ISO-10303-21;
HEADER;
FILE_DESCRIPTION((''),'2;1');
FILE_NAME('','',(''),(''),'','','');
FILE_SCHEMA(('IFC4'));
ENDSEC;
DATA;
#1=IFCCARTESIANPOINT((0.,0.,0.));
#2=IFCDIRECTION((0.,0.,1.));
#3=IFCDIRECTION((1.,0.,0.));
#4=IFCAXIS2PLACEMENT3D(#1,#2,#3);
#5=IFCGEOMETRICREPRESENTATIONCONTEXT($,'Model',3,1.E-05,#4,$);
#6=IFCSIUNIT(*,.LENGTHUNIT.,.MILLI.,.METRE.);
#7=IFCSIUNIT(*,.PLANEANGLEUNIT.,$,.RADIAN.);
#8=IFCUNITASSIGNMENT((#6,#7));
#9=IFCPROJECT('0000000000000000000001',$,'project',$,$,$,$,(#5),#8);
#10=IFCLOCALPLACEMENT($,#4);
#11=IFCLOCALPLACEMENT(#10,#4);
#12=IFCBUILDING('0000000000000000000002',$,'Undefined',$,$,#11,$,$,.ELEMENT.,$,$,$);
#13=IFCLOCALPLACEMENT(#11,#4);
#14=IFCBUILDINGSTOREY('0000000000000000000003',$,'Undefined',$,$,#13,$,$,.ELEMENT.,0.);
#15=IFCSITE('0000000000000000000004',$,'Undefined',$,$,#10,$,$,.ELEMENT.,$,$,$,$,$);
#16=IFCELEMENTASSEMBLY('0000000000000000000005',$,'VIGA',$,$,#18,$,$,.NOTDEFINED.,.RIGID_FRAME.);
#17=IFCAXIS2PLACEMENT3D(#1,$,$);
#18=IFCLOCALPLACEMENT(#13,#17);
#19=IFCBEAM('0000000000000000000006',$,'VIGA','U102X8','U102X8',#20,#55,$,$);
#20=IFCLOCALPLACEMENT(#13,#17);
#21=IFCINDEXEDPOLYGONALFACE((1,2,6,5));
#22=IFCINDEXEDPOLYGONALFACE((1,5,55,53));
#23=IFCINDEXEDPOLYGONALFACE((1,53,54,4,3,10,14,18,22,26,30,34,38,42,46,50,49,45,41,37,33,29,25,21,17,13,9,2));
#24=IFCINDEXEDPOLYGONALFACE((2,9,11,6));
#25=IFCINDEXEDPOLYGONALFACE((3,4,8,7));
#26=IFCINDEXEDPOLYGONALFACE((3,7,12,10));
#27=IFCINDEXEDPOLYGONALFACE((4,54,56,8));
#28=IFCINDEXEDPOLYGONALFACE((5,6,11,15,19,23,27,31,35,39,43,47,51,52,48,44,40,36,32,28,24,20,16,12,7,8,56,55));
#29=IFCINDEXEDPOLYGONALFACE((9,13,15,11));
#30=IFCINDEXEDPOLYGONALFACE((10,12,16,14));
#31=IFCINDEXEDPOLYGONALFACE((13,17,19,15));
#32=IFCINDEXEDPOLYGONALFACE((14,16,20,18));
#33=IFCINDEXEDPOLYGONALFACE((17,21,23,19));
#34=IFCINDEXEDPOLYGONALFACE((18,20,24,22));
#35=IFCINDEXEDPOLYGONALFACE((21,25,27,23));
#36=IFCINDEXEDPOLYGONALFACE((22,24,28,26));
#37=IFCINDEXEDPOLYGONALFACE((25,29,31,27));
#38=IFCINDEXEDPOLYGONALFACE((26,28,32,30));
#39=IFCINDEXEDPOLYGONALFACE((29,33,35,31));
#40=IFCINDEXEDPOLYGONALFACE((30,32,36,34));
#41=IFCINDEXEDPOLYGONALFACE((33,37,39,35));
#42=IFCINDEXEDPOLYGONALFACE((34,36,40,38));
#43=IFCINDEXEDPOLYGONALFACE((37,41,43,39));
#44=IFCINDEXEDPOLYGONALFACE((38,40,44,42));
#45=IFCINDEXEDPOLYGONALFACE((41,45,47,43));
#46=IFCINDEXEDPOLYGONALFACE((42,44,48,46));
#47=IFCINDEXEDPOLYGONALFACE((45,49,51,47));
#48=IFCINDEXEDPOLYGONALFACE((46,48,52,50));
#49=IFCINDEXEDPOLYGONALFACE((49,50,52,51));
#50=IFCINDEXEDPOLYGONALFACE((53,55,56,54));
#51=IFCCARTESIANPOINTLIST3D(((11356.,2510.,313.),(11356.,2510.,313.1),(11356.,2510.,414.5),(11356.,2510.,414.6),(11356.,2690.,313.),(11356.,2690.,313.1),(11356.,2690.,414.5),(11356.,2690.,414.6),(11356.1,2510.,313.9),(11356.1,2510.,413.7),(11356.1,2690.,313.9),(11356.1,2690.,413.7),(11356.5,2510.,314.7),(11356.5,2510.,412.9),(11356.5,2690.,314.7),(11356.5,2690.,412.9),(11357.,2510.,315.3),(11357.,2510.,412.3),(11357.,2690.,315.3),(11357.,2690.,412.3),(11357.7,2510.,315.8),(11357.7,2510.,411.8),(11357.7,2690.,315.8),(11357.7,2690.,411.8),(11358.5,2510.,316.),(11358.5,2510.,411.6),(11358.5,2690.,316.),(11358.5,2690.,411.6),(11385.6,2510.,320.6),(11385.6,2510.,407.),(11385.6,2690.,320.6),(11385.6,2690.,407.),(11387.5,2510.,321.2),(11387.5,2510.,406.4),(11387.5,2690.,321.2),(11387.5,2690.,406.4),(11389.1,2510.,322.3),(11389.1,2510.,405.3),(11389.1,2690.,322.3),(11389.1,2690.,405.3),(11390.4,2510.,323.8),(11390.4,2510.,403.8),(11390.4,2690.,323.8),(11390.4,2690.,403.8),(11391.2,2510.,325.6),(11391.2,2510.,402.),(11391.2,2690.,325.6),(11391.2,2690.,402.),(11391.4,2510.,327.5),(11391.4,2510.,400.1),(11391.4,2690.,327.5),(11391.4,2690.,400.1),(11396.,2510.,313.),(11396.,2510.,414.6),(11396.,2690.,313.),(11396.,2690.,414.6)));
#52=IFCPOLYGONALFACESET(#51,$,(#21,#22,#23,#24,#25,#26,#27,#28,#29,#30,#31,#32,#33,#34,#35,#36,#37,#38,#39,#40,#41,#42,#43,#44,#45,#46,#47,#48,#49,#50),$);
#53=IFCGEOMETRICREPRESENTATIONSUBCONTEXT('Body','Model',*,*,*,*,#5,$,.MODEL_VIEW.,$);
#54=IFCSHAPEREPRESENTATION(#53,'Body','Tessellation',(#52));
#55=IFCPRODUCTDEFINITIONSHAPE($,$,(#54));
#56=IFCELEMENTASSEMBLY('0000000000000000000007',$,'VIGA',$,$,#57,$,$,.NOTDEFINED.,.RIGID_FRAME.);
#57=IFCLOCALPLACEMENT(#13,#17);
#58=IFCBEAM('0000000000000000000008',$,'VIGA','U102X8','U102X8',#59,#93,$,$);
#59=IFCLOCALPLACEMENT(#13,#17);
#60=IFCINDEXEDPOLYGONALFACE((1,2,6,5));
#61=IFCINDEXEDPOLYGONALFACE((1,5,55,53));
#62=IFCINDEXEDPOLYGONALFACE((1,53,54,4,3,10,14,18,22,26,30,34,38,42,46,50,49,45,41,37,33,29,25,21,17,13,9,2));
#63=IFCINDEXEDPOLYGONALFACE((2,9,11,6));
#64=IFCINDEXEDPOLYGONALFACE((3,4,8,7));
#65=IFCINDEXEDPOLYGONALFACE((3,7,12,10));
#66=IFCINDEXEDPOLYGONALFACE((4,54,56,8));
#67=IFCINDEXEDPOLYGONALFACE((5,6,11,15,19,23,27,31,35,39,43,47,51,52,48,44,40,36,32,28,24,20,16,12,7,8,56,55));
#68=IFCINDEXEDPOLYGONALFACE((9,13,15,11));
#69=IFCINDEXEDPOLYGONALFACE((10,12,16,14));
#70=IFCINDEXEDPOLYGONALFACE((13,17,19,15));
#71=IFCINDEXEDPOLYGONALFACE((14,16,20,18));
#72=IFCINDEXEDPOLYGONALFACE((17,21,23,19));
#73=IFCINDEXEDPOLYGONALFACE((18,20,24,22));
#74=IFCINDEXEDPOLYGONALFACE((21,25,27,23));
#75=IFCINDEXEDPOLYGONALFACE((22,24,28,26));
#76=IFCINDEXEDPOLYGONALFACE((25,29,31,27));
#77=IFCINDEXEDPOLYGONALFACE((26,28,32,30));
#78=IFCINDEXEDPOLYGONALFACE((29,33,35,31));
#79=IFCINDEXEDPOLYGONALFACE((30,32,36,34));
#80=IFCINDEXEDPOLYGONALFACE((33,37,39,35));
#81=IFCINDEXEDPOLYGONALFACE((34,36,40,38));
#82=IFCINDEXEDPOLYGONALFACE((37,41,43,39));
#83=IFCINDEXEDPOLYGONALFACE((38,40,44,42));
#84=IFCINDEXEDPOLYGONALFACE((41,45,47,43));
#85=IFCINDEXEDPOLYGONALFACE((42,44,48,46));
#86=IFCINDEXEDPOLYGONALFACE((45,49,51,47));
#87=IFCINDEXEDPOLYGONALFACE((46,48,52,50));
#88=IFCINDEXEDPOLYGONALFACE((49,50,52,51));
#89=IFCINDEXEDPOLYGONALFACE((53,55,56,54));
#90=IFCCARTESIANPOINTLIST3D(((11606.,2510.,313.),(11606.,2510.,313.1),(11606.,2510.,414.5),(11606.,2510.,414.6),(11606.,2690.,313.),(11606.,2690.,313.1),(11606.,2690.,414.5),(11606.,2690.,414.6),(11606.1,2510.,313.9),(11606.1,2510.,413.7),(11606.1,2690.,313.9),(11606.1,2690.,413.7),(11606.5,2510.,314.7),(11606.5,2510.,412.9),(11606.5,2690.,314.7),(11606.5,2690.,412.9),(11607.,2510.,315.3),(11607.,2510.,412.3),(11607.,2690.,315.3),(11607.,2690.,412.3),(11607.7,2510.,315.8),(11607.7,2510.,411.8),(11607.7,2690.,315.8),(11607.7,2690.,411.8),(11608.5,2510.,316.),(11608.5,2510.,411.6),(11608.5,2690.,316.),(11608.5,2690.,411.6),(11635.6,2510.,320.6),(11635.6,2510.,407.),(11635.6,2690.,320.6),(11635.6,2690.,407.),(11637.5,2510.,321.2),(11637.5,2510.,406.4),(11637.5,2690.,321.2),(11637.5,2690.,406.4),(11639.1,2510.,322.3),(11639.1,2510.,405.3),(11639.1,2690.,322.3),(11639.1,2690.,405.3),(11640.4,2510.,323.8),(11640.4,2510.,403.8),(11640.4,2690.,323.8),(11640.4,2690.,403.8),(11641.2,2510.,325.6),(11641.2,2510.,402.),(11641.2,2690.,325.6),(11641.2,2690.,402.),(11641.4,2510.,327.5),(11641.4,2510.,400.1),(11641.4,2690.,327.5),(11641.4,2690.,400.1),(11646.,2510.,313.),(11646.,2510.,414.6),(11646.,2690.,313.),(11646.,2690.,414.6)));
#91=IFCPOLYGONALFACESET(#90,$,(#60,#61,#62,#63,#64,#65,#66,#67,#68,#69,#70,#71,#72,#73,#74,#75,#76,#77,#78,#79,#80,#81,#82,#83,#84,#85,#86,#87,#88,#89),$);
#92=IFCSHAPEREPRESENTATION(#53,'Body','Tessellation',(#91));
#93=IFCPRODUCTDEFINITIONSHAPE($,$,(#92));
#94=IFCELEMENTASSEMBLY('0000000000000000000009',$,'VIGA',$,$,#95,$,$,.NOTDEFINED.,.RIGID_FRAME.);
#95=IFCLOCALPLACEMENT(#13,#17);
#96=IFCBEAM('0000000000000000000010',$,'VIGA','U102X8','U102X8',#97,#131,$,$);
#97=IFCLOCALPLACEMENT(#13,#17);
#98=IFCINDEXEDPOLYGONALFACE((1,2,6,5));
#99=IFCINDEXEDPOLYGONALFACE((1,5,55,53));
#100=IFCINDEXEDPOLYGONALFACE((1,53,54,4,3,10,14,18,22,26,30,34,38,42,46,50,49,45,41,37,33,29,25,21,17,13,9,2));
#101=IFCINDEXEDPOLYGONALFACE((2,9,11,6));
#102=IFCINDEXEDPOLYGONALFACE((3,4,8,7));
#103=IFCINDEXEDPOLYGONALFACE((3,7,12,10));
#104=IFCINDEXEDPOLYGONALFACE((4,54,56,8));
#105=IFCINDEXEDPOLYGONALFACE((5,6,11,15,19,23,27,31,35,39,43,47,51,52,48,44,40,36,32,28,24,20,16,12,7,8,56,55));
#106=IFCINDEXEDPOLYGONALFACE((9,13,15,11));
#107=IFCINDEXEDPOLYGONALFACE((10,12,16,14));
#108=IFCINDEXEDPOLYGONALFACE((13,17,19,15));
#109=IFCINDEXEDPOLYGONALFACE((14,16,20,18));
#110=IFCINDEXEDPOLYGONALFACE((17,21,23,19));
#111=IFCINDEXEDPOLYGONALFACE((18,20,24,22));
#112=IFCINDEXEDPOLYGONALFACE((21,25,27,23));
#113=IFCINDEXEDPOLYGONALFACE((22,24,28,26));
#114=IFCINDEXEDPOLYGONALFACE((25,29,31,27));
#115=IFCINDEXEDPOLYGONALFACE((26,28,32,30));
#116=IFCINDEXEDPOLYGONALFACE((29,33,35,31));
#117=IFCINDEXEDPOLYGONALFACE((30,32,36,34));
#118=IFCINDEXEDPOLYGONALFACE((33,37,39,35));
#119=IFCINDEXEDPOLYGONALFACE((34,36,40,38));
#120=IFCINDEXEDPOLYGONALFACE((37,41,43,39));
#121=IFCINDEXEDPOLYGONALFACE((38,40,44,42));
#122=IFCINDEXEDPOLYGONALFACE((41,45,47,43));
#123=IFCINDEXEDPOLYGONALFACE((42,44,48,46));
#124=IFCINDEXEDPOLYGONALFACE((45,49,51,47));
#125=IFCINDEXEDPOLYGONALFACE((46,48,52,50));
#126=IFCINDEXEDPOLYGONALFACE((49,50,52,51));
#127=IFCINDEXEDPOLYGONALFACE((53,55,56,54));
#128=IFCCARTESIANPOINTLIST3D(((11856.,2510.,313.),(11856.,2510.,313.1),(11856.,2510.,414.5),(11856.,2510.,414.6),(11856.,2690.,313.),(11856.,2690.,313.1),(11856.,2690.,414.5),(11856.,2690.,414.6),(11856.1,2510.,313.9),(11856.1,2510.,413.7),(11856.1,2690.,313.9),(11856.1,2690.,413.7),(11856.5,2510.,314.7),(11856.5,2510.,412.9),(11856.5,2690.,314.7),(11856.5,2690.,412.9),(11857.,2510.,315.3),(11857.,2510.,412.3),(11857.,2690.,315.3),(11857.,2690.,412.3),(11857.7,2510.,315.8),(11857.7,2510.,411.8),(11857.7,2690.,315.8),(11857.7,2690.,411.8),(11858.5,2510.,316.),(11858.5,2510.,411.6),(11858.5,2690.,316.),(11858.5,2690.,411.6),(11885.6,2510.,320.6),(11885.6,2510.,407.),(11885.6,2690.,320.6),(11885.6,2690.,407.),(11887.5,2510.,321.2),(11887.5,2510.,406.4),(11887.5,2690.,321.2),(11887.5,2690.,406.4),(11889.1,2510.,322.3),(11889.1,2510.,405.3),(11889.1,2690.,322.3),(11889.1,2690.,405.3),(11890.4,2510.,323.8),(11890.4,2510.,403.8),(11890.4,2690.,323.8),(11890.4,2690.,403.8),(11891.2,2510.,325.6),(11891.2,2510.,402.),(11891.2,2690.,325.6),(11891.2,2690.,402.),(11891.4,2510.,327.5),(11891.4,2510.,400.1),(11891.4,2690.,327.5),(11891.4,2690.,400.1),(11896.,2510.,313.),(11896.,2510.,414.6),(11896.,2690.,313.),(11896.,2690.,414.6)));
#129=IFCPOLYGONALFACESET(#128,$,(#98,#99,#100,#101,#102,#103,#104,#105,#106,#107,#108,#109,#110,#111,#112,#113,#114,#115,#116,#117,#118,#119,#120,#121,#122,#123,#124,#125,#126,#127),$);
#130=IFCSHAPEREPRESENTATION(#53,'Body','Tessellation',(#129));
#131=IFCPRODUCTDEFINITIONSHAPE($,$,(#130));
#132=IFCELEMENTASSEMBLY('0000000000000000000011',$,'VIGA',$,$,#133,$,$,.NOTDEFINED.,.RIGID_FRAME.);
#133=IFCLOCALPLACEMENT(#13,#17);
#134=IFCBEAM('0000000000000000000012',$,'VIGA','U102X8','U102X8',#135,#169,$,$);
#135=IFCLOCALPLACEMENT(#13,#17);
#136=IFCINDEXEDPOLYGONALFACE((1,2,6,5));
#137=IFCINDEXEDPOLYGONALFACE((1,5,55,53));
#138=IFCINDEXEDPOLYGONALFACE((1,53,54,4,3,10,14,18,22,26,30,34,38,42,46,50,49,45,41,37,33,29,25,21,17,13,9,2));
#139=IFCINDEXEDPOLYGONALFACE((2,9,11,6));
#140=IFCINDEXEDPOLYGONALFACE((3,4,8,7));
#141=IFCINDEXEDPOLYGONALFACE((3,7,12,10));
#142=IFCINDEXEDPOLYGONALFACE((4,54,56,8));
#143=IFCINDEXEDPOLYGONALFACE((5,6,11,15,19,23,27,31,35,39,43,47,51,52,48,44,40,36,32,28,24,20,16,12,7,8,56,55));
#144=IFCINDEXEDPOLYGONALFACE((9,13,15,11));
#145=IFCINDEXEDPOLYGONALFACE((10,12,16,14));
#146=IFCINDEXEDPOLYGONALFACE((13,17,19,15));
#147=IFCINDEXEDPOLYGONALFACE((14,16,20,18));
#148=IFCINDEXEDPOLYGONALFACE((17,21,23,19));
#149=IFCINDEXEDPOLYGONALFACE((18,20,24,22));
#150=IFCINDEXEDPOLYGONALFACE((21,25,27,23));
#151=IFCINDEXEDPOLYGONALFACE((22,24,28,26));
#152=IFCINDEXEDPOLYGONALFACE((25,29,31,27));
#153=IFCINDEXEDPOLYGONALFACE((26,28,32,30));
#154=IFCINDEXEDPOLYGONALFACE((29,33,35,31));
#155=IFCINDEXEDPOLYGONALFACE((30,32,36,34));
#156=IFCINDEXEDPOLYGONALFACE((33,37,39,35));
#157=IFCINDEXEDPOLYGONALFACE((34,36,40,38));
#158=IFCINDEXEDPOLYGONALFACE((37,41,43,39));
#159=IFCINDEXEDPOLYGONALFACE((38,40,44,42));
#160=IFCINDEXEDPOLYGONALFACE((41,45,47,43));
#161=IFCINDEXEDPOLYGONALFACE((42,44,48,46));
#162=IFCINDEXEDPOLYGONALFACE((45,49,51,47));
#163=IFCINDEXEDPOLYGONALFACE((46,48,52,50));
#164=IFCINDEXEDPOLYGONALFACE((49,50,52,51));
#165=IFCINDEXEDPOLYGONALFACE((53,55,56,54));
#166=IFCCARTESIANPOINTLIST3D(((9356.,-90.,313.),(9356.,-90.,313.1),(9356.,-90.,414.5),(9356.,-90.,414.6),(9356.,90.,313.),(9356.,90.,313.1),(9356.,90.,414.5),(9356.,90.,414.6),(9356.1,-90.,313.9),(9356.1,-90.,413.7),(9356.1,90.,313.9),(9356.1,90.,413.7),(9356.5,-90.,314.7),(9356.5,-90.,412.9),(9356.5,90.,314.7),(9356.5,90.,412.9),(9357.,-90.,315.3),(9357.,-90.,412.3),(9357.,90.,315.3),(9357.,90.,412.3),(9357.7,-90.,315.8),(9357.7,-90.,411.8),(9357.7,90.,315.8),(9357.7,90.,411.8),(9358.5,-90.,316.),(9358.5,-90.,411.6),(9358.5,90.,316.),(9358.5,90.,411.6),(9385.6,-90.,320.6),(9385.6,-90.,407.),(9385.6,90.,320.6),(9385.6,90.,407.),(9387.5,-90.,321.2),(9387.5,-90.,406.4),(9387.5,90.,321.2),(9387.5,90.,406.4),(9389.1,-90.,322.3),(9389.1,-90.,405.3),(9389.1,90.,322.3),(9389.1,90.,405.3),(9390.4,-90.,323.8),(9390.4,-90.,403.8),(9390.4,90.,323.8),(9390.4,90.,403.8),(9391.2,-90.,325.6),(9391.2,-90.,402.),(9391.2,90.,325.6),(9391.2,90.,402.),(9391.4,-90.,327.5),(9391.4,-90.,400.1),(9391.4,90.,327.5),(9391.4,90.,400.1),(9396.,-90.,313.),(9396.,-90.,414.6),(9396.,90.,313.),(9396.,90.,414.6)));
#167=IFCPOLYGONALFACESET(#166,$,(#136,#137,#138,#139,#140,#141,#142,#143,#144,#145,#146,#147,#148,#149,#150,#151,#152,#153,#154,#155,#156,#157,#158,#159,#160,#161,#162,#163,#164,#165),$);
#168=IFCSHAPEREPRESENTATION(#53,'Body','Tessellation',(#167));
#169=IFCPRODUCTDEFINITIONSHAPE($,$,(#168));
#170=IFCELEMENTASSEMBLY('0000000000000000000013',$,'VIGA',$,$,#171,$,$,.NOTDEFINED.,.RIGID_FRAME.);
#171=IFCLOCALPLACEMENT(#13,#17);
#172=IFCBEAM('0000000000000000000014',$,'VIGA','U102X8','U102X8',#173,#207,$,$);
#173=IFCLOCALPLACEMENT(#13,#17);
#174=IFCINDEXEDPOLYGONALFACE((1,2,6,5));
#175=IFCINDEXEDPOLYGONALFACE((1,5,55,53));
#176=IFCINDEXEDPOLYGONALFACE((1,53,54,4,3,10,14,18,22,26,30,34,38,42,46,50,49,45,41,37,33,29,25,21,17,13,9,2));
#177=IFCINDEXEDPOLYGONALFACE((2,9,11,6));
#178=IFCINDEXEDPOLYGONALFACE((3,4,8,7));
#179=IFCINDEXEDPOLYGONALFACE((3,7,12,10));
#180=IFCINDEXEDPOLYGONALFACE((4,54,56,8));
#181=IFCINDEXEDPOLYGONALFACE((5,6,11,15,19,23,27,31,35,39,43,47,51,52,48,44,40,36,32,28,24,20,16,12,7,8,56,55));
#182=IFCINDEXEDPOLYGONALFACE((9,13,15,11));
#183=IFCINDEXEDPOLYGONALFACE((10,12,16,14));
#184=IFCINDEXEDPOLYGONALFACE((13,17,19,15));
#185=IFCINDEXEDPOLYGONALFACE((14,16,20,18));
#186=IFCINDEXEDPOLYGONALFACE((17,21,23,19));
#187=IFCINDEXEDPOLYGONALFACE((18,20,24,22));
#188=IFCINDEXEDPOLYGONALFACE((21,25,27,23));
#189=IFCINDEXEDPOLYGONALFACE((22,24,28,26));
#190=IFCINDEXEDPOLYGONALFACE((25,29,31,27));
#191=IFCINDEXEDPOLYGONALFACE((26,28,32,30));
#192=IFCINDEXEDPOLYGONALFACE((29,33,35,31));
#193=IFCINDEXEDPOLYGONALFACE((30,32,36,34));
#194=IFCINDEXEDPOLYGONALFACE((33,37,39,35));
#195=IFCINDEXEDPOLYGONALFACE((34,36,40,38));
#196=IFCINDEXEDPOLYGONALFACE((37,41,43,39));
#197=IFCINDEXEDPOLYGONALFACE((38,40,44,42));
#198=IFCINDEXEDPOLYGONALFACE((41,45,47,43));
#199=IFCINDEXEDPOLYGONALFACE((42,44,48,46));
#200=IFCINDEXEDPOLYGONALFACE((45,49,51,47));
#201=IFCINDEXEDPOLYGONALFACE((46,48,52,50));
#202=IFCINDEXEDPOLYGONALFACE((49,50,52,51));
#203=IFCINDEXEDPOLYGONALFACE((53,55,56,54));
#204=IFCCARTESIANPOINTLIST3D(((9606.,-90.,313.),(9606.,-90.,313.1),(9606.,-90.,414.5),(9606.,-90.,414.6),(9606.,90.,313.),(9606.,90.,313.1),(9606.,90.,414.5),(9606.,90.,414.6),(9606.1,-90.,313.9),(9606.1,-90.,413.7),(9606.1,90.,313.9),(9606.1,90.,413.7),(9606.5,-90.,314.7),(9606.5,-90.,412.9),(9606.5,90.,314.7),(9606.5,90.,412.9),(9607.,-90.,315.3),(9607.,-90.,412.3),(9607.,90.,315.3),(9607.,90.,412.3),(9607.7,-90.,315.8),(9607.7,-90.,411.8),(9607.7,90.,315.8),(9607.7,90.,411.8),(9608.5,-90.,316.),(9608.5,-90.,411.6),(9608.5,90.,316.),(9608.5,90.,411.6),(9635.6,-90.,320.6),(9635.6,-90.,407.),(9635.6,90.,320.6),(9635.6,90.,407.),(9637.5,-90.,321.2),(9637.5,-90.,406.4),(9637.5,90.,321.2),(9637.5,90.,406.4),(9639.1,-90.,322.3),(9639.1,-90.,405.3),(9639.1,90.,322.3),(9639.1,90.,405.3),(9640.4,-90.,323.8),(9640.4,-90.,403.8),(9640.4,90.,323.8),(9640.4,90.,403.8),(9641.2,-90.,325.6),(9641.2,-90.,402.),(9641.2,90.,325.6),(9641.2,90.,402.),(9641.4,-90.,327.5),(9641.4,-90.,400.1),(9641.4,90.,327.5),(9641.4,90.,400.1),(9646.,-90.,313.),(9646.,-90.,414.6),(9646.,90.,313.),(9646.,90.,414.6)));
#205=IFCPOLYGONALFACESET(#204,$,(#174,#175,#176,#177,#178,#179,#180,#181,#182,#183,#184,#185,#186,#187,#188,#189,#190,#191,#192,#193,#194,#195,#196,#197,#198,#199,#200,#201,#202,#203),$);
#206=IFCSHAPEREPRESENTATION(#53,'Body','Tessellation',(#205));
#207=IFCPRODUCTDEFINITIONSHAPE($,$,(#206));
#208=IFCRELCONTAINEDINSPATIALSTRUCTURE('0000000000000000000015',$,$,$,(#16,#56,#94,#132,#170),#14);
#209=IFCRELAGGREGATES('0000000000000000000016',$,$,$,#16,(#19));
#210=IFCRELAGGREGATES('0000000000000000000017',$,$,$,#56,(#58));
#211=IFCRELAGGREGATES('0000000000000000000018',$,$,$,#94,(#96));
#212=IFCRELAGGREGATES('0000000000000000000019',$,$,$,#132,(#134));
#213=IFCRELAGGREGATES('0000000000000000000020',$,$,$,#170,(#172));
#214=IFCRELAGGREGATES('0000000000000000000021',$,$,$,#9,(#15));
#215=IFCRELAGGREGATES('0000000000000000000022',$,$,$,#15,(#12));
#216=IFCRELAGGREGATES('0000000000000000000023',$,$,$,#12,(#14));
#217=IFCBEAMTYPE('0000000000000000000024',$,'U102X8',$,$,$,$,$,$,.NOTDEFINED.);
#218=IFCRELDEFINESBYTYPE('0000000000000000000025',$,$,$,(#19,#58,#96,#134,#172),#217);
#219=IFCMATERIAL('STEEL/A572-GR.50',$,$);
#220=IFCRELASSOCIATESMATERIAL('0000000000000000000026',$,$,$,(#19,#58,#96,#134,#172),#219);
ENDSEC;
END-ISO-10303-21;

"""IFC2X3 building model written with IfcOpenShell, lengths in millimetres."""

from ifc_helpers import new_model, si_unit, frame, origin_with_axes, origin_2d_with_axis, place, context, subcontext, project, spatial, u_section, extrude, material, type_object, element, aggregate, save


model = new_model("IFC2X3")

# Units and contexts
model_context = context("Model", 3, precision=1e-05, world=origin_with_axes())
body_context = subcontext(model_context, "Body", "Model", "MODEL_VIEW")
ifc_project = project(units=[si_unit("LENGTHUNIT", "METRE", prefix="MILLI"), si_unit("PLANEANGLEUNIT", "RADIAN")], contexts=[model_context])

# Site, building, storey
site_placement = place(None, origin_with_axes())
site = spatial("IfcSite", under=ifc_project, at=site_placement, Name="Undefined", CompositionType="ELEMENT")
building_placement = place(site_placement, origin_with_axes())
building = spatial("IfcBuilding", under=site, at=building_placement, Name="Undefined", CompositionType="ELEMENT")
storey_placement = place(building_placement, origin_with_axes())
storey = spatial("IfcBuildingStorey", under=building, at=storey_placement, Name="Undefined", CompositionType="ELEMENT", Elevation=0.0)

# Element assemblies, beams
ifc_material_1 = material(Name="STEEL/A572-GR.50")
beam_type_1 = type_object("IfcBeamType", Name="U102X8", PredefinedType="NOTDEFINED")
assembly_1_placement = place(storey_placement, origin_with_axes())
assembly_1 = element("IfcElementAssembly", 1, at=assembly_1_placement, inside=storey, Name="VIGA", AssemblyPlace="NOTDEFINED", PredefinedType="RIGID_FRAME")
beam_1_placement = place(assembly_1_placement, frame((11376.0, 2690.0, 363.8), z_axis=(0.0, 0.0, 1.0), x_axis=(0.0, -1.0, 0.0)))
beam_1 = element("IfcBeam", 2, at=beam_1_placement, type_object=beam_type_1, material=ifc_material_1, Name="VIGA", Description="U102X8", ObjectType="U102X8", context=body_context, shape_type="SweptSolid", body=[
    extrude(u_section(Depth=101.6, FlangeWidth=40.0, WebThickness=4.6, FlangeThickness=6.0, FilletRadius=7.0, EdgeRadius=3.0, FlangeSlope=0.16839, at=origin_2d_with_axis()), frame((180.0, 0.0, 0.0), z_axis=(-1.0, 0.0, 0.0), x_axis=(0.0, -1.0, 0.0)), (0.0, 0.0, 1.0), 180.0),
])
aggregate(assembly_1, [beam_1])
assembly_2_placement = place(storey_placement, origin_with_axes())
assembly_2 = element("IfcElementAssembly", 3, at=assembly_2_placement, inside=storey, Name="VIGA", AssemblyPlace="NOTDEFINED", PredefinedType="RIGID_FRAME")
beam_2_placement = place(assembly_2_placement, frame((11626.0, 2690.0, 363.8), z_axis=(0.0, 0.0, 1.0), x_axis=(0.0, -1.0, 0.0)))
beam_2 = element("IfcBeam", 4, at=beam_2_placement, type_object=beam_type_1, material=ifc_material_1, Name="VIGA", Description="U102X8", ObjectType="U102X8", context=body_context, shape_type="SweptSolid", body=[
    extrude(u_section(Depth=101.6, FlangeWidth=40.0, WebThickness=4.6, FlangeThickness=6.0, FilletRadius=7.0, EdgeRadius=3.0, FlangeSlope=0.16839, at=origin_2d_with_axis()), frame((180.0, 0.0, 0.0), z_axis=(-1.0, 0.0, 0.0), x_axis=(0.0, -1.0, 0.0)), (0.0, 0.0, 1.0), 180.0),
])
aggregate(assembly_2, [beam_2])
assembly_3_placement = place(storey_placement, origin_with_axes())
assembly_3 = element("IfcElementAssembly", 5, at=assembly_3_placement, inside=storey, Name="VIGA", AssemblyPlace="NOTDEFINED", PredefinedType="RIGID_FRAME")
beam_3_placement = place(assembly_3_placement, frame((11876.0, 2690.0, 363.8), z_axis=(0.0, 0.0, 1.0), x_axis=(0.0, -1.0, 0.0)))
beam_3 = element("IfcBeam", 6, at=beam_3_placement, type_object=beam_type_1, material=ifc_material_1, Name="VIGA", Description="U102X8", ObjectType="U102X8", context=body_context, shape_type="SweptSolid", body=[
    extrude(u_section(Depth=101.6, FlangeWidth=40.0, WebThickness=4.6, FlangeThickness=6.0, FilletRadius=7.0, EdgeRadius=3.0, FlangeSlope=0.16839, at=origin_2d_with_axis()), frame((180.0, 0.0, 0.0), z_axis=(-1.0, 0.0, 0.0), x_axis=(0.0, -1.0, 0.0)), (0.0, 0.0, 1.0), 180.0),
])
aggregate(assembly_3, [beam_3])
assembly_4_placement = place(storey_placement, origin_with_axes())
assembly_4 = element("IfcElementAssembly", 7, at=assembly_4_placement, inside=storey, Name="VIGA", AssemblyPlace="NOTDEFINED", PredefinedType="RIGID_FRAME")
beam_4_placement = place(assembly_4_placement, frame((9376.0, 90.0, 363.8), z_axis=(0.0, 0.0, 1.0), x_axis=(0.0, -1.0, 0.0)))
beam_4 = element("IfcBeam", 8, at=beam_4_placement, type_object=beam_type_1, material=ifc_material_1, Name="VIGA", Description="U102X8", ObjectType="U102X8", context=body_context, shape_type="SweptSolid", body=[
    extrude(u_section(Depth=101.6, FlangeWidth=40.0, WebThickness=4.6, FlangeThickness=6.0, FilletRadius=7.0, EdgeRadius=3.0, FlangeSlope=0.16839, at=origin_2d_with_axis()), frame((180.0, 0.0, 0.0), z_axis=(-1.0, 0.0, 0.0), x_axis=(0.0, -1.0, 0.0)), (0.0, 0.0, 1.0), 180.0),
])
aggregate(assembly_4, [beam_4])
assembly_5_placement = place(storey_placement, origin_with_axes())
assembly_5 = element("IfcElementAssembly", 9, at=assembly_5_placement, inside=storey, Name="VIGA", AssemblyPlace="NOTDEFINED", PredefinedType="RIGID_FRAME")
beam_5_placement = place(assembly_5_placement, frame((9626.0, 90.0, 363.8), z_axis=(0.0, 0.0, 1.0), x_axis=(0.0, -1.0, 0.0)))
beam_5 = element("IfcBeam", 10, at=beam_5_placement, type_object=beam_type_1, material=ifc_material_1, Name="VIGA", Description="U102X8", ObjectType="U102X8", context=body_context, shape_type="SweptSolid", body=[
    extrude(u_section(Depth=101.6, FlangeWidth=40.0, WebThickness=4.6, FlangeThickness=6.0, FilletRadius=7.0, EdgeRadius=3.0, FlangeSlope=0.16839, at=origin_2d_with_axis()), frame((180.0, 0.0, 0.0), z_axis=(-1.0, 0.0, 0.0), x_axis=(0.0, -1.0, 0.0)), (0.0, 0.0, 1.0), 180.0),
])
aggregate(assembly_5, [beam_5])

save(model, "model.ifc")
